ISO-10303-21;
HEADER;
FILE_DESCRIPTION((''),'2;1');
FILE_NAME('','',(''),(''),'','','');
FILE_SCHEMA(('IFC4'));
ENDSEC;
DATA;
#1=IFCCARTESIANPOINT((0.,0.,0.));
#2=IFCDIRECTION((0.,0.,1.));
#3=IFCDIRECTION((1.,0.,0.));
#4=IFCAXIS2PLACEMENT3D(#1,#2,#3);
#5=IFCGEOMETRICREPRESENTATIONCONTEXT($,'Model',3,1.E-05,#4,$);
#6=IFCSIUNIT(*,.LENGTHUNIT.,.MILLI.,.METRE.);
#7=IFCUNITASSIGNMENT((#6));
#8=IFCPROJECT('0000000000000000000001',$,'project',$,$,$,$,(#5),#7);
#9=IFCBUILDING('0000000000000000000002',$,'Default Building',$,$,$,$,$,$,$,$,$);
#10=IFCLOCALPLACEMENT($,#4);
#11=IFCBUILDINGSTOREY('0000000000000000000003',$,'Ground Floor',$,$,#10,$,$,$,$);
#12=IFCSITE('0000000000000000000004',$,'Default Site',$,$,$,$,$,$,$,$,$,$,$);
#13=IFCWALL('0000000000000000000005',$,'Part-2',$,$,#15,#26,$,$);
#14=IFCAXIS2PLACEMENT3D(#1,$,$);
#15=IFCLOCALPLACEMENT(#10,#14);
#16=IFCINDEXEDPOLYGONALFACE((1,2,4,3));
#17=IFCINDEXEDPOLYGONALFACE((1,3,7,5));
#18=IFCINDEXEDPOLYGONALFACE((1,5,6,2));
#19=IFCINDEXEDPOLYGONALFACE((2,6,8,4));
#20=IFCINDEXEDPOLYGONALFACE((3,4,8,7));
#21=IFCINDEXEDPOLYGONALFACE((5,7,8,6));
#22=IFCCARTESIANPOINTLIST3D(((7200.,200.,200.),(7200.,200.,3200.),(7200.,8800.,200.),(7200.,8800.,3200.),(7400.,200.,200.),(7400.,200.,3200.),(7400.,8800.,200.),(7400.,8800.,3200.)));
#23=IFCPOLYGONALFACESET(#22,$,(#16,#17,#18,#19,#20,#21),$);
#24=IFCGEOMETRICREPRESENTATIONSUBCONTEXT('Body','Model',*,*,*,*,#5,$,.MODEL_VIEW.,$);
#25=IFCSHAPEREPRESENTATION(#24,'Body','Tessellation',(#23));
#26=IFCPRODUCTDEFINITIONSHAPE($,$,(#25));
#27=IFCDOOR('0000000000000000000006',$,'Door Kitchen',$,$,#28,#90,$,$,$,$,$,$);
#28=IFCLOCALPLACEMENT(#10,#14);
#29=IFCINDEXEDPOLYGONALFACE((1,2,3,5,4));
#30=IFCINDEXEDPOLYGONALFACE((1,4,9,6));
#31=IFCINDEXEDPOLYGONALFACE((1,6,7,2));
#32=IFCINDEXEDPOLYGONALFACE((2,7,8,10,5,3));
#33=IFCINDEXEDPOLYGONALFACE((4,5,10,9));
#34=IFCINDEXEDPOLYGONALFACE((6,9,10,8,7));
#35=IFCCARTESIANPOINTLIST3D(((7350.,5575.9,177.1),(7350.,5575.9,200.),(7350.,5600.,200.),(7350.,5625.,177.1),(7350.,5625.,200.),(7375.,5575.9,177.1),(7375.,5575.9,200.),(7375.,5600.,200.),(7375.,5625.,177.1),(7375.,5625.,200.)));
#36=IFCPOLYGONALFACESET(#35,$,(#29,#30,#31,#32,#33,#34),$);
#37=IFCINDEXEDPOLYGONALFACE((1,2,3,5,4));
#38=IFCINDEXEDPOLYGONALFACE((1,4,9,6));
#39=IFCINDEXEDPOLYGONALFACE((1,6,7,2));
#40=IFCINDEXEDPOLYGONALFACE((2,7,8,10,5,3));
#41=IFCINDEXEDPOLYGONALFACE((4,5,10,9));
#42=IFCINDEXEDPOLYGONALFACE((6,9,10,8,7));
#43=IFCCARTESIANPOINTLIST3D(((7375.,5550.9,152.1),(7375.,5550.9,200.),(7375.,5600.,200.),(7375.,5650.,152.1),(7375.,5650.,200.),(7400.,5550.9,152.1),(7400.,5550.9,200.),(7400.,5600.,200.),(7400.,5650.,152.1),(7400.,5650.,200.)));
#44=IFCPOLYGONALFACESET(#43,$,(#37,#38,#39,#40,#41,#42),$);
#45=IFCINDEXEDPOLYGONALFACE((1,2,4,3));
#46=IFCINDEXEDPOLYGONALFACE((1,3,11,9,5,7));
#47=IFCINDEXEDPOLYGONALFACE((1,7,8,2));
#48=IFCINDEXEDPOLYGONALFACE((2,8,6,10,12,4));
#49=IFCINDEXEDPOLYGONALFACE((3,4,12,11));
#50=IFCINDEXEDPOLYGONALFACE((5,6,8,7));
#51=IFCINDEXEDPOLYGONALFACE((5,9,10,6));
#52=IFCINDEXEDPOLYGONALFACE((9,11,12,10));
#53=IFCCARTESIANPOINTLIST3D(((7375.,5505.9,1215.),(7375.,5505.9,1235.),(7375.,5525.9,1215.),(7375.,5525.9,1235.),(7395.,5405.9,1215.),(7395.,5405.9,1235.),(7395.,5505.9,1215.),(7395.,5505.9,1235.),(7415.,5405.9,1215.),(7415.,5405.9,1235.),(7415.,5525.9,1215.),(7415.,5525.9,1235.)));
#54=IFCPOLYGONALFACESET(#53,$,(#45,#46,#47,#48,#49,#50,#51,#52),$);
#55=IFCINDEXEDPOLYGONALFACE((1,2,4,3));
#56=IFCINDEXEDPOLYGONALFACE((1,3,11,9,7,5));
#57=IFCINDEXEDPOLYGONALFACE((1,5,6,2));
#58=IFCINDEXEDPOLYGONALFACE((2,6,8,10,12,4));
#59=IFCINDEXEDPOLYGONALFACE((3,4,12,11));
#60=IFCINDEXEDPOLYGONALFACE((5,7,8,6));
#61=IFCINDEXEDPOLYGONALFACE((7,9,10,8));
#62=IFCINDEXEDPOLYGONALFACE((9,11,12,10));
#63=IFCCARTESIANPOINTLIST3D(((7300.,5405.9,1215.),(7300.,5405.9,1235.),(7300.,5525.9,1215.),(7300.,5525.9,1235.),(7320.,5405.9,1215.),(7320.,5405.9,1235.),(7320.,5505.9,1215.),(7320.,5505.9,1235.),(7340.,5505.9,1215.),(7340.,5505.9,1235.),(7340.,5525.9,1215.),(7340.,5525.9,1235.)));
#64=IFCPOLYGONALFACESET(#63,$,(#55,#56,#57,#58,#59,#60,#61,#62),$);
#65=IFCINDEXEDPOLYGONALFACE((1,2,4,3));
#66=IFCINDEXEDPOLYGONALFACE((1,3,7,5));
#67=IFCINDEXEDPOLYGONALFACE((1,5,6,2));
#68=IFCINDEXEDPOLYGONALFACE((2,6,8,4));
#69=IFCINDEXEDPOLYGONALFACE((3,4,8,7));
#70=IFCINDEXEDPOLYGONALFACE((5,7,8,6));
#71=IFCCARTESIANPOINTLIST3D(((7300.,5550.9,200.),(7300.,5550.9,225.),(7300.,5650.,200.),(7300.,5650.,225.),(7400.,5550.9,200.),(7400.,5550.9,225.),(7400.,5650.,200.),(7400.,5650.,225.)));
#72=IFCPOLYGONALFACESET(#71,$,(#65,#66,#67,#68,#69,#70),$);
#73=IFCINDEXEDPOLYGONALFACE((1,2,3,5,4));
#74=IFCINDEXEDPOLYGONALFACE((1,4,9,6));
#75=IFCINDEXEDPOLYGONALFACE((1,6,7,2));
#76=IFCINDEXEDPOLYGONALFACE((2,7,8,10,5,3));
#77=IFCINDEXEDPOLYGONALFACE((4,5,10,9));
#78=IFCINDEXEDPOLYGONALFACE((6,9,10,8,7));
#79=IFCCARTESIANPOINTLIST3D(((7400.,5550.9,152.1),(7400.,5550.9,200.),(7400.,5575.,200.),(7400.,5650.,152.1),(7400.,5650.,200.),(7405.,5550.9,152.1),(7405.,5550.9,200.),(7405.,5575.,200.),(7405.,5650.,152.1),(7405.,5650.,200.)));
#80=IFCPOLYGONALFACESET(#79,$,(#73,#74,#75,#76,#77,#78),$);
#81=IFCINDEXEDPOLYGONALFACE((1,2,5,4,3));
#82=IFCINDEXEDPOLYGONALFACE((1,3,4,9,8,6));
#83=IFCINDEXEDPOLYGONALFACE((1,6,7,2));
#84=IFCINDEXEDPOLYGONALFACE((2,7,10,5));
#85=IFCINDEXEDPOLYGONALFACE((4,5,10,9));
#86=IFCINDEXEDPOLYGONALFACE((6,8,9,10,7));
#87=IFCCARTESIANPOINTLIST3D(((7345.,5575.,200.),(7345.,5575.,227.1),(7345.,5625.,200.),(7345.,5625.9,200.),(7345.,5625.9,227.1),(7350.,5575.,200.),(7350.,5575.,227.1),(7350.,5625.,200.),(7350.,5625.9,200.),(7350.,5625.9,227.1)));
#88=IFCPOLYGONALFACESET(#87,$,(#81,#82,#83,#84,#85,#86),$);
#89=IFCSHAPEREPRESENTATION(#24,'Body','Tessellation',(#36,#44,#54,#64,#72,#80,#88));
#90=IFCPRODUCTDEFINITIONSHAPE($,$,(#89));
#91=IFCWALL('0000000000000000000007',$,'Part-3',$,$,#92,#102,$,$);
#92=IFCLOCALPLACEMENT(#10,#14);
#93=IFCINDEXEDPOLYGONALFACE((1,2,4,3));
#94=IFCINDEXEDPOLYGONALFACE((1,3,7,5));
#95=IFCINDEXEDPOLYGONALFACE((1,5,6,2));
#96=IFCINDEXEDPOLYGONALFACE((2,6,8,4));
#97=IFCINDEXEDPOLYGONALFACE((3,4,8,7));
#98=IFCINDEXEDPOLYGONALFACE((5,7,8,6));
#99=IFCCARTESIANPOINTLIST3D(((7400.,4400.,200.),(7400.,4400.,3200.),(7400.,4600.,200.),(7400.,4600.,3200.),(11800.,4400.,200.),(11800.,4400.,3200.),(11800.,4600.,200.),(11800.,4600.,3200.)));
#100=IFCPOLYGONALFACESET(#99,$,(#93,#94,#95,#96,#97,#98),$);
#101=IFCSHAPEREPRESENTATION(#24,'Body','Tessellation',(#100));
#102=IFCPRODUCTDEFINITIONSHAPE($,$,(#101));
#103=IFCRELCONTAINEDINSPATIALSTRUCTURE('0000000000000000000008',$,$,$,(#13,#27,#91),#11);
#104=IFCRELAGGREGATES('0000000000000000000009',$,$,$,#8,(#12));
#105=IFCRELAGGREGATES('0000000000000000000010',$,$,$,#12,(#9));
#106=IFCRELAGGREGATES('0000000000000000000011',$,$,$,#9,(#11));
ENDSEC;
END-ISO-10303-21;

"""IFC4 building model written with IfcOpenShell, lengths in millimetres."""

from ifc_helpers import new_model, si_unit, frame, origin_with_axes, place, context, subcontext, project, spatial, line, indexed_curve, outline, extrude, element, fill, save


model = new_model("IFC4")

# Units and contexts
model_context = context("Model", 3, precision=1e-05, world=origin_with_axes())
body_context = subcontext(model_context, "Body", "Model", "MODEL_VIEW")
ifc_project = project(units=[si_unit("LENGTHUNIT", "METRE", prefix="MILLI")], contexts=[model_context])

# Site, building, storey
site = spatial("IfcSite", under=ifc_project, Name="Default Site")
building = spatial("IfcBuilding", under=site, Name="Default Building")
storey_placement = place(None, origin_with_axes())
storey = spatial("IfcBuildingStorey", under=building, at=storey_placement, Name="Ground Floor")

# Wall, opening, door
wall_1_placement = place(storey_placement, frame((0.0, 0.0, 200.0), z_axis=(0.0, 0.0, 1.0), x_axis=(1.0, 0.0, 0.0)))
wall_1 = element("IfcWall", 1, at=wall_1_placement, inside=storey, Name="Part-2", context=body_context, shape_type="SweptSolid", body=[
    extrude(outline(indexed_curve([(7400.0, 200.0), (7400.0, 8800.0), (7200.0, 8800.0), (7200.0, 200.0), (7400.0, 200.0)])), None, (0.0, 0.0, 1.0), 3000.0),
])
opening_1_placement = place(wall_1_placement, origin_with_axes())
opening_1 = element("IfcOpeningElement", 2, at=opening_1_placement, cuts=wall_1, context=body_context, shape_type="SweptSolid", body=[
    extrude(outline(indexed_curve([(7400.0, 5600.0), (7600.0, 5600.0), (7600.0, 6500.0), (7400.0, 6500.0), (7400.0, 5600.0)])), None, (0.0, 0.0, 1.0), 2100.0),
])
door_1_placement = place(storey_placement, frame((7400.0, 5600.0, 200.0), z_axis=(0.0, 0.0, 1.0), x_axis=(0.0, 1.0, 0.0)))
door_1 = element("IfcDoor", 3, at=door_1_placement, inside=storey, Name="Door Kitchen", context=body_context, shape_type="SweptSolid", body=[
    extrude(outline(indexed_curve([(0.0, 0.0), (0.0, 2.1), (0.9, 2.1), (0.9, 0.0), (-24.1, 0.0), (-24.1, -22.9), (25.0, -22.9), (25.0, 0.0)], segments=[line(1, 2, 3, 4, 5, 6, 7, 8, 1)])), frame((0.0, 25.0, 0.0), z_axis=(0.0, -1.0, 0.0), x_axis=(1.0, 0.0, 0.0)), (0.0, 0.0, -1.0), 25.0),
    extrude(outline(indexed_curve([(0.0, 0.0), (0.0, 2.1), (0.9, 2.1), (0.9, 0.0), (-49.1, 0.0), (-49.1, -47.9), (50.0, -47.9), (50.0, 0.0)], segments=[line(1, 2, 3, 4, 5, 6, 7, 8, 1)])), frame((0.0, 0.0, 0.0), z_axis=(0.0, -1.0, 0.0), x_axis=(1.0, 0.0, 0.0)), (0.0, 0.0, -1.0), 25.0),
    extrude(outline(indexed_curve([(0.0, 0.0), (-49.1, 0.0), (-49.1, 35.0), (0.0, 35.0)], segments=[line(1, 2, 3, 4, 1)])), frame((25.0, 25.0, 25.0), z_axis=(0.0, 0.0, 1.0), x_axis=(1.0, 0.0, 0.0)), (0.0, 0.0, 1.0), -47.9),
    extrude(outline(indexed_curve([(0.0, 0.0), (0.0, -40.0), (-120.0, -40.0), (-120.0, -20.0), (-20.0, -20.0), (-20.0, 0.0)], segments=[line(1, 2, 3, 4, 5, 6, 1)])), frame((-74.1, 25.0, 1015.0), z_axis=(0.0, 0.0, 1.0), x_axis=(1.0, 0.0, 0.0)), (0.0, 0.0, 1.0), 20.0),
    extrude(outline(indexed_curve([(0.0, 0.0), (0.0, 40.0), (-120.0, 40.0), (-120.0, 20.0), (-20.0, 20.0), (-20.0, 0.0)], segments=[line(1, 2, 3, 4, 5, 6, 1)])), frame((-74.1, 60.0, 1015.0), z_axis=(0.0, 0.0, 1.0), x_axis=(1.0, 0.0, 0.0)), (0.0, 0.0, 1.0), 20.0),
    extrude(outline(indexed_curve([(0.0, 0.0), (-99.1, 0.0), (-99.1, 100.0), (0.0, 100.0)], segments=[line(1, 2, 3, 4, 1)])), frame((50.0, 0.0, 0.0), z_axis=(0.0, 0.0, 1.0), x_axis=(1.0, 0.0, 0.0)), (0.0, 0.0, 1.0), 25.0),
    extrude(outline(indexed_curve([(0.0, 0.0), (0.0, 27.1), (50.9, 27.1), (50.9, 0.0), (-24.1, 0.0), (-24.1, -47.9), (75.0, -47.9), (75.0, 0.0)], segments=[line(1, 2, 3, 4, 5, 6, 7, 8, 1)])), frame((-25.0, -5.0, 0.0), z_axis=(0.0, -1.0, 0.0), x_axis=(1.0, 0.0, 0.0)), (0.0, 0.0, -1.0), 5.0),
    extrude(outline(indexed_curve([(0.0, 0.0), (0.0, 27.1), (50.9, 27.1), (50.9, 0.0), (0.9, 0.0), (0.9, -22.9), (50.0, -22.9), (50.0, 0.0)], segments=[line(1, 2, 3, 4, 5, 6, 7, 8, 1)])), frame((-25.0, 50.0, 0.0), z_axis=(0.0, -1.0, 0.0), x_axis=(1.0, 0.0, 0.0)), (0.0, 0.0, -1.0), 5.0),
])
fill(opening_1, door_1)

# Wall
wall_2_placement = place(storey_placement, frame((0.0, 0.0, 200.0), z_axis=(0.0, 0.0, 1.0), x_axis=(1.0, 0.0, 0.0)))
element("IfcWall", 4, at=wall_2_placement, inside=storey, Name="Part-3", context=body_context, shape_type="SweptSolid", body=[
    extrude(outline(indexed_curve([(7400.0, 4400.0), (11800.0, 4400.0), (11800.0, 4600.0), (7400.0, 4600.0), (7400.0, 4400.0)])), None, (0.0, 0.0, 1.0), 3000.0),
])

save(model, "model.ifc")
